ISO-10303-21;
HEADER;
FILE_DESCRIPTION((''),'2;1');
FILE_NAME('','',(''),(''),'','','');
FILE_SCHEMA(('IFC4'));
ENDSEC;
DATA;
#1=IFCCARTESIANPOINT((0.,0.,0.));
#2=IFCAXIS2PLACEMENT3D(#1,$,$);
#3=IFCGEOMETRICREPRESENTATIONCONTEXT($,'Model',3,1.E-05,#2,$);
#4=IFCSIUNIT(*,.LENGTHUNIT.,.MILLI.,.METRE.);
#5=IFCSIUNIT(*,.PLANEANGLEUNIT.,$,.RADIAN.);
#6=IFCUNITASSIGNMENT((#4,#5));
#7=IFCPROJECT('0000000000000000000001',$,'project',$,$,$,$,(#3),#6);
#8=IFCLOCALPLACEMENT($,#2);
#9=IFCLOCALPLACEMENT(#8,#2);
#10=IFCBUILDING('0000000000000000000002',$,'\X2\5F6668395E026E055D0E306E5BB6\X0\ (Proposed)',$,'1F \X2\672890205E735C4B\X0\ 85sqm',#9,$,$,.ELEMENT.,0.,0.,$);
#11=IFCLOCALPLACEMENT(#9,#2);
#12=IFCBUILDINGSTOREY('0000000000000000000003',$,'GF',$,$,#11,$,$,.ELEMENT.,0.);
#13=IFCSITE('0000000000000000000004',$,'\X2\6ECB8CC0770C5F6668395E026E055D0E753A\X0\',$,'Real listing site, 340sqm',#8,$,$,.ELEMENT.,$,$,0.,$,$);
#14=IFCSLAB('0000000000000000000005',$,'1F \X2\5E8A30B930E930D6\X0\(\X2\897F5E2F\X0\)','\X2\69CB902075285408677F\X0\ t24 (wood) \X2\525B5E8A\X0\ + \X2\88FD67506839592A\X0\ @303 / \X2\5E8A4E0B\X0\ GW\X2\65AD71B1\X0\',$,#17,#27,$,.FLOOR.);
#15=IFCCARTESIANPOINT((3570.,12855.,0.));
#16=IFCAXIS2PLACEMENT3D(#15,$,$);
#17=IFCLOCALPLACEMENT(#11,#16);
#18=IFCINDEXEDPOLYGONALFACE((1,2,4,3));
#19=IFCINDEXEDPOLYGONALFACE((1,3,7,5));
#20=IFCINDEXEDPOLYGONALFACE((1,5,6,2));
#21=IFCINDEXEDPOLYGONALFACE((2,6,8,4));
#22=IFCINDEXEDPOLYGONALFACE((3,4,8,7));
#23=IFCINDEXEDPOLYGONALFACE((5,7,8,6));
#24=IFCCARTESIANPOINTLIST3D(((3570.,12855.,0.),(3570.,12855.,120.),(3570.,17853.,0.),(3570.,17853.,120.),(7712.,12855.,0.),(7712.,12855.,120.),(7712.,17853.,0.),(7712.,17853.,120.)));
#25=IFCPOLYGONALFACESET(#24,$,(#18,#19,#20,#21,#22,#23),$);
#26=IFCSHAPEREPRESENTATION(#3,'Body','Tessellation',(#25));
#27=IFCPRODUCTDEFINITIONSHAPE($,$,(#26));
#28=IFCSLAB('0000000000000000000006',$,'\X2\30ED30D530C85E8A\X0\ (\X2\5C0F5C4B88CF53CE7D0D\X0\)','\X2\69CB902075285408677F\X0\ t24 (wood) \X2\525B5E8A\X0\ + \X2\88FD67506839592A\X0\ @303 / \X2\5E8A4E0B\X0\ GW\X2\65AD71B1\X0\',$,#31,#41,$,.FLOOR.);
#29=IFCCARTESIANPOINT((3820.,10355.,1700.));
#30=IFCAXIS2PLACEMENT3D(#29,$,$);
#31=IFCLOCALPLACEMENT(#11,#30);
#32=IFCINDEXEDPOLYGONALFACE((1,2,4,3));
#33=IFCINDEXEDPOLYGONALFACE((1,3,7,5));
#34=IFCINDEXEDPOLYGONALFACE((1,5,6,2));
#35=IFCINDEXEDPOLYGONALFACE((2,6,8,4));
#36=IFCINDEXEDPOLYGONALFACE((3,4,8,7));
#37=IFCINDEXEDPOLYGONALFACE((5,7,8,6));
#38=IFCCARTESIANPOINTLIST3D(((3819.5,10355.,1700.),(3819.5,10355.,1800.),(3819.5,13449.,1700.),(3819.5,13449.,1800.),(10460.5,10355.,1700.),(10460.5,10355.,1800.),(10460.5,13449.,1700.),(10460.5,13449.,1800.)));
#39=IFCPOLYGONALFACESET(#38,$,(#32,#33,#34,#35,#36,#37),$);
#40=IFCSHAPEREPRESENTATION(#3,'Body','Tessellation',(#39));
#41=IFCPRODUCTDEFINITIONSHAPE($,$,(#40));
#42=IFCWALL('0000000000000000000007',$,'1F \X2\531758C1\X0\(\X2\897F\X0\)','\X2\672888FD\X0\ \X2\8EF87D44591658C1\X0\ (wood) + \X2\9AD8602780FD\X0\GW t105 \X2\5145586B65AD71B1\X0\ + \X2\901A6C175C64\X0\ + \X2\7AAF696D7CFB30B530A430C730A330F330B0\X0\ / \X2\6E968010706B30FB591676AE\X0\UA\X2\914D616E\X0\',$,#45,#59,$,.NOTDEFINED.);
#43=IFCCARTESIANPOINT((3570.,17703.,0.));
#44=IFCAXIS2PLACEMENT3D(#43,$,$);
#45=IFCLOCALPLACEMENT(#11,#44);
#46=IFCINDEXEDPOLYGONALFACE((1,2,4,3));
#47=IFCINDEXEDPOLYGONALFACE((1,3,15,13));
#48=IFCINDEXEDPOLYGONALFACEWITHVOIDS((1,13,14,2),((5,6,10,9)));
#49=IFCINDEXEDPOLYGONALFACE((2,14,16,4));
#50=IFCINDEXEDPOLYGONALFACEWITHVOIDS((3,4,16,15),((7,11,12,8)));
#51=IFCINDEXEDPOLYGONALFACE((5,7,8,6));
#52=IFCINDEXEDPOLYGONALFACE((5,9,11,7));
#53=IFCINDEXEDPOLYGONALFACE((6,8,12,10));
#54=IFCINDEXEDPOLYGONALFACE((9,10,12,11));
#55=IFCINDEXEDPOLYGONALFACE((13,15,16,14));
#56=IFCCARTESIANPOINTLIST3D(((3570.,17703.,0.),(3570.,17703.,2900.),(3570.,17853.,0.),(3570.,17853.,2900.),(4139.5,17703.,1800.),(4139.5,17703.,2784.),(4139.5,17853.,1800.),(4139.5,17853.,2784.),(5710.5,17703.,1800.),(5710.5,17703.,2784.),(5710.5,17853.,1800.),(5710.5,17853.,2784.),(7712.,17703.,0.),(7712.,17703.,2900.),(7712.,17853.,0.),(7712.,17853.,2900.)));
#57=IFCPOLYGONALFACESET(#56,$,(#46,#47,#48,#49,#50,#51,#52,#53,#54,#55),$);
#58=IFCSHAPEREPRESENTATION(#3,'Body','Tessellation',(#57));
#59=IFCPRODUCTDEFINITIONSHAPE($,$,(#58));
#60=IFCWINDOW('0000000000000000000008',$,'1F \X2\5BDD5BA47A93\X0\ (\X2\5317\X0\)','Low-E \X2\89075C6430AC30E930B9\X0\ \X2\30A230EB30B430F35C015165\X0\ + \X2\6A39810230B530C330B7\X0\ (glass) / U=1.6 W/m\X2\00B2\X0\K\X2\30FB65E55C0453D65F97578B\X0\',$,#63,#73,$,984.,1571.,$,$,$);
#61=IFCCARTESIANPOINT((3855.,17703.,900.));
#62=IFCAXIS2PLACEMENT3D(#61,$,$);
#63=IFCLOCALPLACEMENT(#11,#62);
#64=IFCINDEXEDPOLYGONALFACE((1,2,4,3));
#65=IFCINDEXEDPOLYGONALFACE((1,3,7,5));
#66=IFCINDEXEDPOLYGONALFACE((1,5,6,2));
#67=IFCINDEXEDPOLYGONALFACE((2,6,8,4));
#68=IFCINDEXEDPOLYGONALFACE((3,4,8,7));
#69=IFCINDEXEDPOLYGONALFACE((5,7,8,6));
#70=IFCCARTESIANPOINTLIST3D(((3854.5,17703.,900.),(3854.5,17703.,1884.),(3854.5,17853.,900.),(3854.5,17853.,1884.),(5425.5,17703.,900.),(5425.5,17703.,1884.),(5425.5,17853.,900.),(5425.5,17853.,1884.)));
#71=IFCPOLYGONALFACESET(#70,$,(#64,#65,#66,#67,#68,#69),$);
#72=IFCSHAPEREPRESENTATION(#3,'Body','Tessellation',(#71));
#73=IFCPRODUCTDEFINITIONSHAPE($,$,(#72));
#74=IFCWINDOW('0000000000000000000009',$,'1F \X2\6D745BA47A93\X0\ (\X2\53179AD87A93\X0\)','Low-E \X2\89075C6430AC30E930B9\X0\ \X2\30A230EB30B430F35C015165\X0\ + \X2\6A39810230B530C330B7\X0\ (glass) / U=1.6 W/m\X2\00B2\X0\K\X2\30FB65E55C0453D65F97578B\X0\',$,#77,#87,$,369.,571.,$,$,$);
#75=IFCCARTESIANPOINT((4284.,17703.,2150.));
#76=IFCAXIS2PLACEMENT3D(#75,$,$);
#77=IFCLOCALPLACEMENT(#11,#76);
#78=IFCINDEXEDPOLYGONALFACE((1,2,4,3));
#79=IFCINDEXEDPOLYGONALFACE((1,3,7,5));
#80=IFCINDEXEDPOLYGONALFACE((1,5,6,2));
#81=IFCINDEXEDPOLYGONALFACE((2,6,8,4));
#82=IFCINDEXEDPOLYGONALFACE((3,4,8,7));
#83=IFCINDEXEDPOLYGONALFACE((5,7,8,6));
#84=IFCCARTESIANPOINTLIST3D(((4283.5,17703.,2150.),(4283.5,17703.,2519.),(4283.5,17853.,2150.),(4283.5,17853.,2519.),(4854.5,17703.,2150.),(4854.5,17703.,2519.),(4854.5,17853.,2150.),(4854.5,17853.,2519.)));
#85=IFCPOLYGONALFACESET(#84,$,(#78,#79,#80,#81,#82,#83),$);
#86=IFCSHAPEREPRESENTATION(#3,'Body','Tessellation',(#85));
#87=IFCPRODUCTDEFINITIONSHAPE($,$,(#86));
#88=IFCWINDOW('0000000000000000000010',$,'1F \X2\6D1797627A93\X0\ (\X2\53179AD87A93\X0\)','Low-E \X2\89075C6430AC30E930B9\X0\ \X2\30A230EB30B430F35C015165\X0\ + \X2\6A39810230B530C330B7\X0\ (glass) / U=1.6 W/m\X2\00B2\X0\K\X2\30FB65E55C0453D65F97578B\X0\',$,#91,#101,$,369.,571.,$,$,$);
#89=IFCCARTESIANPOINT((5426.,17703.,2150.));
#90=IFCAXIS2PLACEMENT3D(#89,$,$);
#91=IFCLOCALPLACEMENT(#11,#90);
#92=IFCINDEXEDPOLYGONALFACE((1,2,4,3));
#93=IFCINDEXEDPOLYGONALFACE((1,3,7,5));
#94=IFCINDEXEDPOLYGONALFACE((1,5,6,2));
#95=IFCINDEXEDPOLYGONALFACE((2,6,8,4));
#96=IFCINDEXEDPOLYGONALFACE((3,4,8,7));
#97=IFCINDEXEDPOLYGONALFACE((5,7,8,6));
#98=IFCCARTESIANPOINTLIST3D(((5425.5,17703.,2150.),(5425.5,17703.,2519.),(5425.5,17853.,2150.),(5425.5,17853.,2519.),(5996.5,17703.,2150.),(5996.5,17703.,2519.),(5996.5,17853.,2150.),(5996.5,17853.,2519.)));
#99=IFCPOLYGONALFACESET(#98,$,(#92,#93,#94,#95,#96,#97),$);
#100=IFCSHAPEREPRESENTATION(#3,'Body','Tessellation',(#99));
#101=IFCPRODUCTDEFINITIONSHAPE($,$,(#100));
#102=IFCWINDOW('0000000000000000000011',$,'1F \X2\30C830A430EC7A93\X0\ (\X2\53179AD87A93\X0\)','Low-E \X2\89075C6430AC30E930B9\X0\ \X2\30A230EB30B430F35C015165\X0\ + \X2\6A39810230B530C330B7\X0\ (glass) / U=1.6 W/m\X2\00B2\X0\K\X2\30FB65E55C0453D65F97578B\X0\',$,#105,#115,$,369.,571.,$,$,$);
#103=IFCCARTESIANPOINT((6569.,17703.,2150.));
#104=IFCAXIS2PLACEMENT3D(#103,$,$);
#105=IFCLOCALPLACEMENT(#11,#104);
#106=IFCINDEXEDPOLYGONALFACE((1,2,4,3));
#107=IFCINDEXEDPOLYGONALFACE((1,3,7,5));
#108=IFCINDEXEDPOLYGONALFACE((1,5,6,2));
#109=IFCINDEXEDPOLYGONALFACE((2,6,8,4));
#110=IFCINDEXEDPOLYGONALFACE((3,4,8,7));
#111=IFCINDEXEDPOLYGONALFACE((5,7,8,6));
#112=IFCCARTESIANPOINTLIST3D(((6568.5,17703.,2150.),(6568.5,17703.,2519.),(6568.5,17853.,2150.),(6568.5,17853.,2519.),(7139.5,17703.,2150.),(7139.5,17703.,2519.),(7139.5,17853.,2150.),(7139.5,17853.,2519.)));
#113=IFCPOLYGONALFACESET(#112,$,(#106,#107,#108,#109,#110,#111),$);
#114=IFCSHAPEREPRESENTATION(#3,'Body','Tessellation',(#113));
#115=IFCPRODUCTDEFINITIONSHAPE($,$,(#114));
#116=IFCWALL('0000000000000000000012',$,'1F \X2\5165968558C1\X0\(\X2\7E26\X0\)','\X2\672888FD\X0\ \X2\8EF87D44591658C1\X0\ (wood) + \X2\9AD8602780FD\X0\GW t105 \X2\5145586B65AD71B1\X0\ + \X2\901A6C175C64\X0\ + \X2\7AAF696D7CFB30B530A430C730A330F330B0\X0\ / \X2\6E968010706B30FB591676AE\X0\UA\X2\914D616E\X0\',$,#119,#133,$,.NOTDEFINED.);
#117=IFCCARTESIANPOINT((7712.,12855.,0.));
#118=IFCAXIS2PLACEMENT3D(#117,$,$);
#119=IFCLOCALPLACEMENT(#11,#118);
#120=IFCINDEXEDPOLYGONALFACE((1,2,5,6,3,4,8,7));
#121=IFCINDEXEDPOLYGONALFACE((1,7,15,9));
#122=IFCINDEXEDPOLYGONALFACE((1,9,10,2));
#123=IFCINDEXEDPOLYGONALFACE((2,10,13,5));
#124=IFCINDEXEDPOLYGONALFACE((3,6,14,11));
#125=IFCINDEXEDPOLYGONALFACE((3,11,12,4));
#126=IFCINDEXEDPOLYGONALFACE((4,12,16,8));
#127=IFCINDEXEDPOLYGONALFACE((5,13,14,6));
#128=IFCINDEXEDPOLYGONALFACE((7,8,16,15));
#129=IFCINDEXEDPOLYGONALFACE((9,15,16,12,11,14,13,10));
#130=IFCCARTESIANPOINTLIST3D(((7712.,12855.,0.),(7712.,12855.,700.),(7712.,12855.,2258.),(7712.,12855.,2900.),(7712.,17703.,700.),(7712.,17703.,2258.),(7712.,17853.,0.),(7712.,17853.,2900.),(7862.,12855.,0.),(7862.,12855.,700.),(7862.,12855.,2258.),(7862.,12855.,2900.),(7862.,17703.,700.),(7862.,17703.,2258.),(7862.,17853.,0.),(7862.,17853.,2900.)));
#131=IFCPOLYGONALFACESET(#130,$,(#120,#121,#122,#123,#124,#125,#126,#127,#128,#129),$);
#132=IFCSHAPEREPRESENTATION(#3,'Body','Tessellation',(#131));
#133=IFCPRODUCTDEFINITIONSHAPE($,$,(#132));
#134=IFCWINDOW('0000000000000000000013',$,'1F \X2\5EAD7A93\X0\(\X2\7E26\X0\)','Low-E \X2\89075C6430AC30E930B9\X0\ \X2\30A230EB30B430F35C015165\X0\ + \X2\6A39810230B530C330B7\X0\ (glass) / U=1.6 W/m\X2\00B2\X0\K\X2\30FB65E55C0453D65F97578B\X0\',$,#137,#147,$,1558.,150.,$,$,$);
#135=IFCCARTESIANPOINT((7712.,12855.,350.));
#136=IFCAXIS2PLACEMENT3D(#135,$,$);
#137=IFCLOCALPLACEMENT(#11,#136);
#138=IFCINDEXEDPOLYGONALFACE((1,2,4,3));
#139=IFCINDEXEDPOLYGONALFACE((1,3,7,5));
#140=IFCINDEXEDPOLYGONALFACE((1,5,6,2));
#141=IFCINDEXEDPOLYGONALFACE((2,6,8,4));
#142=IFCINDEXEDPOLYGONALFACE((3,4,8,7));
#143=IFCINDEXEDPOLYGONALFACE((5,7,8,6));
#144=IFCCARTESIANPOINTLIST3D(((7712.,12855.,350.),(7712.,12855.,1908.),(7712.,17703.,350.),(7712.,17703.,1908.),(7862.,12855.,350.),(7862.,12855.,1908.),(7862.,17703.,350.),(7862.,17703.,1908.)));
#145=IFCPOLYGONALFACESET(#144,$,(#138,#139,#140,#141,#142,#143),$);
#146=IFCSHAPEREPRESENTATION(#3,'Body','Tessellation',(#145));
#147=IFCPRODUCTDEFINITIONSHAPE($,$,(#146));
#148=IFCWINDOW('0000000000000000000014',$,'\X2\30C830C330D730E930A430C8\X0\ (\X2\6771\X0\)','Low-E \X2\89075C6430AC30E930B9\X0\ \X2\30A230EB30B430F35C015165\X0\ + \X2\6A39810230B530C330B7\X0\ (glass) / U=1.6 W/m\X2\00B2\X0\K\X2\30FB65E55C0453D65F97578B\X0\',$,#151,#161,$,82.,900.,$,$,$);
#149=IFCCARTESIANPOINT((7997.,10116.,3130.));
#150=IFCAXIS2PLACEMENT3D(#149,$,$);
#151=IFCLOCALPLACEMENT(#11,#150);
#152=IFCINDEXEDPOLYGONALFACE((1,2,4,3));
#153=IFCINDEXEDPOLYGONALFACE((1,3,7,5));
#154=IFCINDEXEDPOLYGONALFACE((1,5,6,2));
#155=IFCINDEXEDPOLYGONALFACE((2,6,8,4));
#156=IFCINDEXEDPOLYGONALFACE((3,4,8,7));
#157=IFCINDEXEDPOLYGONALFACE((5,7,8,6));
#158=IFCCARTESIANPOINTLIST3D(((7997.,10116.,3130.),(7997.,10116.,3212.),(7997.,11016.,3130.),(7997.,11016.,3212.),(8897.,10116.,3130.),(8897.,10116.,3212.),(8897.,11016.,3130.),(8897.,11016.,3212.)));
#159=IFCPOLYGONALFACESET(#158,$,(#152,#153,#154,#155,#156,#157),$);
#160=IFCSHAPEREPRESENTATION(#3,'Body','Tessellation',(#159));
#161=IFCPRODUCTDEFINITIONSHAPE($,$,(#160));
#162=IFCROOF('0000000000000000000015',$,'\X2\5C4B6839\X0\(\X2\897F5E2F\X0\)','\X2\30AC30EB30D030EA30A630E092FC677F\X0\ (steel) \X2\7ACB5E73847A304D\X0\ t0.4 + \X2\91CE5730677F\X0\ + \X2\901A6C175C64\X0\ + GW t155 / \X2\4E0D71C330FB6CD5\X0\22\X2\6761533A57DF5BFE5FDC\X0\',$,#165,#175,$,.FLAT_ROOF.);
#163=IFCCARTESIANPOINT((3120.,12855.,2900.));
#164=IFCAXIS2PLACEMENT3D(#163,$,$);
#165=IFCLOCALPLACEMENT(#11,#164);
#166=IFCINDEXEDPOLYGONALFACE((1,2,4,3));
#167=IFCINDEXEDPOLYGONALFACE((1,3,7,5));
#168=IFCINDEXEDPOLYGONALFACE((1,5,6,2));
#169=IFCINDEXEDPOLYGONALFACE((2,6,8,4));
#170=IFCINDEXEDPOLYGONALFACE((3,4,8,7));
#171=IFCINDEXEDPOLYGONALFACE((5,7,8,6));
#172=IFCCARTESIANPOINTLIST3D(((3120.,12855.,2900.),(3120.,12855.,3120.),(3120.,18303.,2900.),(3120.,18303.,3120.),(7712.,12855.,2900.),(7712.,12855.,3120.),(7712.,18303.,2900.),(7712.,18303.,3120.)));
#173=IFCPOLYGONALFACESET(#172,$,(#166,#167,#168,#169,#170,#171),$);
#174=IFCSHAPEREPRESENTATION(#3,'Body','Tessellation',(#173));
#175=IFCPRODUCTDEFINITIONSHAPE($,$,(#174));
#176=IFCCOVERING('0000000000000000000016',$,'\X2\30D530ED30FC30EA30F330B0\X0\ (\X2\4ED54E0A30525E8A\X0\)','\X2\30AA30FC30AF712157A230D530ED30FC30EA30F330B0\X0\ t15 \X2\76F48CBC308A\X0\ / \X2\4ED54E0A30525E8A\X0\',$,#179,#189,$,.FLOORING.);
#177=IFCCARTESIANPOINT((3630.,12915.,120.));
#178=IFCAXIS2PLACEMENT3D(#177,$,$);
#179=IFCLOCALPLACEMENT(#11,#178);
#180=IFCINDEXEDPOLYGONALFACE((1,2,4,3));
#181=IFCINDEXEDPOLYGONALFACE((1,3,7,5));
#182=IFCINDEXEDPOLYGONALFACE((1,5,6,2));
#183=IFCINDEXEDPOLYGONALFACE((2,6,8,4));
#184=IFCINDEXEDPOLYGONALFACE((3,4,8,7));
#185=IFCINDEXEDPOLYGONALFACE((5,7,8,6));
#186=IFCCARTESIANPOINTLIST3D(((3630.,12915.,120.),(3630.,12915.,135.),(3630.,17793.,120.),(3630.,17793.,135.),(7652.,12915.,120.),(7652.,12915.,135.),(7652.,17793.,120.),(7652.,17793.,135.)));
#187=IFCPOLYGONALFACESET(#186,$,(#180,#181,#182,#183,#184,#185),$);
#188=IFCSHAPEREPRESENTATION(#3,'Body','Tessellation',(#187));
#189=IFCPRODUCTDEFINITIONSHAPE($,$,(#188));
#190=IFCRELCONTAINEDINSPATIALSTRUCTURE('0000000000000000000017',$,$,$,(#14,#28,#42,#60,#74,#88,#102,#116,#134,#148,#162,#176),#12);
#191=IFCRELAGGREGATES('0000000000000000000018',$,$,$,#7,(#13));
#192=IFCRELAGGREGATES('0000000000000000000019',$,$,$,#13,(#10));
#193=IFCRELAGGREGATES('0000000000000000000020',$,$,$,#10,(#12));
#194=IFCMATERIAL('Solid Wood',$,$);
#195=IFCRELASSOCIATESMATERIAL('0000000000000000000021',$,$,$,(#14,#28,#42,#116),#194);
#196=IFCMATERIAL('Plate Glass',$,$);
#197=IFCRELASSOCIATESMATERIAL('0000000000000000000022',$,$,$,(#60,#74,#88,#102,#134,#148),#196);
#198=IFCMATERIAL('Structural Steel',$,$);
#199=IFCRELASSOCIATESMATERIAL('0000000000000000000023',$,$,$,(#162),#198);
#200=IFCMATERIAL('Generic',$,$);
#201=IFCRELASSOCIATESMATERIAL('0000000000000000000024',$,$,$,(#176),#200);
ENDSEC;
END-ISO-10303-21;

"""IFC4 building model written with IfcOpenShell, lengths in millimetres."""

from ifc_helpers import new_model, si_unit, frame, frame_2d, origin, place, context, project, spatial, rectangle, extrude, material, element, fill, save


model = new_model("IFC4")

# Units and contexts
model_context = context("Model", 3, precision=1e-05, world=origin())
ifc_project = project(units=[si_unit("LENGTHUNIT", "METRE", prefix="MILLI"), si_unit("PLANEANGLEUNIT", "RADIAN")], contexts=[model_context])

# Site, building, storey
site_placement = place(None, origin())
site = spatial("IfcSite", under=ifc_project, at=site_placement, Name="滋賀県彦根市清崎町", ObjectType="Real listing site, 340sqm", CompositionType="ELEMENT", RefElevation=0.0)
building_placement = place(site_placement, origin())
building = spatial("IfcBuilding", under=site, at=building_placement, Name="彦根市清崎の家 (Proposed)", ObjectType="1F 木造平屋 85sqm", CompositionType="ELEMENT", ElevationOfRefHeight=0.0, ElevationOfTerrain=0.0)
storey_placement = place(building_placement, origin())
storey = spatial("IfcBuildingStorey", under=building, at=storey_placement, Name="GF", CompositionType="ELEMENT", Elevation=0.0)

# Slabs
ifc_material_1 = material(Name="Solid Wood")
slab_1_placement = place(storey_placement, frame((3570.0, 12855.0, 0.0)))
element("IfcSlab", 1, at=slab_1_placement, inside=storey, material=ifc_material_1, Name="1F 床スラブ(西帯)", Description="構造用合板 t24 (wood) 剛床 + 製材根太 @303 / 床下 GW断熱", PredefinedType="FLOOR", context=model_context, shape_type="SweptSolid", body=[
    extrude(rectangle(XDim=4142.0, YDim=4998.0, at=frame_2d((2071.0, 2499.0))), frame((3570.0, 12855.0, 0.0)), (0.0, 0.0, 1.0), 120.0),
])
slab_2_placement = place(storey_placement, frame((3820.0, 10355.0, 1700.0)))
element("IfcSlab", 2, at=slab_2_placement, inside=storey, material=ifc_material_1, Name="ロフト床 (小屋裏収納)", Description="構造用合板 t24 (wood) 剛床 + 製材根太 @303 / 床下 GW断熱", PredefinedType="FLOOR", context=model_context, shape_type="SweptSolid", body=[
    extrude(rectangle(XDim=6641.0, YDim=3094.0, at=frame_2d((3320.0, 1547.0))), frame((3820.0, 10355.0, 1700.0)), (0.0, 0.0, 1.0), 100.0),
])

# Wall, openings, windows
wall_1_placement = place(storey_placement, frame((3570.0, 17703.0, 0.0)))
wall_1 = element("IfcWall", 3, at=wall_1_placement, inside=storey, material=ifc_material_1, Name="1F 北壁(西)", Description="木製 軸組外壁 (wood) + 高性能GW t105 充填断熱 + 通気層 + 窯業系サイディング / 準耐火・外皮UA配慮", PredefinedType="NOTDEFINED", context=model_context, shape_type="SweptSolid", body=[
    extrude(rectangle(XDim=4142.0, YDim=150.0, at=frame_2d((2071.0, 75.0))), frame((3570.0, 17703.0, 0.0)), (0.0, 0.0, 1.0), 2900.0),
])
opening_1_placement = place(storey_placement, frame((3855.0, 17703.0, 900.0)))
opening_1 = element("IfcOpeningElement", 4, at=opening_1_placement, cuts=wall_1, PredefinedType="NOTDEFINED", context=model_context, shape_type="SweptSolid", body=[
    extrude(rectangle(XDim=1571.0, YDim=150.0, at=frame_2d((785.0, 75.0))), frame((3855.0, 17703.0, 900.0)), (0.0, 0.0, 1.0), 984.0),
])
opening_2_placement = place(storey_placement, frame((4284.0, 17703.0, 2150.0)))
opening_2 = element("IfcOpeningElement", 5, at=opening_2_placement, cuts=wall_1, PredefinedType="NOTDEFINED", context=model_context, shape_type="SweptSolid", body=[
    extrude(rectangle(XDim=571.0, YDim=150.0, at=frame_2d((285.0, 75.0))), frame((4284.0, 17703.0, 2150.0)), (0.0, 0.0, 1.0), 369.0),
])
opening_3_placement = place(storey_placement, frame((5426.0, 17703.0, 2150.0)))
opening_3 = element("IfcOpeningElement", 6, at=opening_3_placement, cuts=wall_1, PredefinedType="NOTDEFINED", context=model_context, shape_type="SweptSolid", body=[
    extrude(rectangle(XDim=571.0, YDim=150.0, at=frame_2d((285.0, 75.0))), frame((5426.0, 17703.0, 2150.0)), (0.0, 0.0, 1.0), 369.0),
])
opening_4_placement = place(storey_placement, frame((6569.0, 17703.0, 2150.0)))
opening_4 = element("IfcOpeningElement", 7, at=opening_4_placement, cuts=wall_1, PredefinedType="NOTDEFINED", context=model_context, shape_type="SweptSolid", body=[
    extrude(rectangle(XDim=571.0, YDim=150.0, at=frame_2d((285.0, 75.0))), frame((6569.0, 17703.0, 2150.0)), (0.0, 0.0, 1.0), 369.0),
])
ifc_material_2 = material(Name="Plate Glass")
window_1_placement = place(storey_placement, frame((3855.0, 17703.0, 900.0)))
window_1 = element("IfcWindow", 8, at=window_1_placement, inside=storey, material=ifc_material_2, Name="1F 寝室窓 (北)", Description="Low-E 複層ガラス アルゴン封入 + 樹脂サッシ (glass) / U=1.6 W/m²K・日射取得型", OverallHeight=984.0, OverallWidth=1571.0, context=model_context, shape_type="SweptSolid", body=[
    extrude(rectangle(XDim=1571.0, YDim=150.0, at=frame_2d((785.0, 75.0))), frame((3855.0, 17703.0, 900.0)), (0.0, 0.0, 1.0), 984.0),
])
fill(opening_1, window_1)
window_2_placement = place(storey_placement, frame((4284.0, 17703.0, 2150.0)))
window_2 = element("IfcWindow", 9, at=window_2_placement, inside=storey, material=ifc_material_2, Name="1F 浴室窓 (北高窓)", Description="Low-E 複層ガラス アルゴン封入 + 樹脂サッシ (glass) / U=1.6 W/m²K・日射取得型", OverallHeight=369.0, OverallWidth=571.0, context=model_context, shape_type="SweptSolid", body=[
    extrude(rectangle(XDim=571.0, YDim=150.0, at=frame_2d((285.0, 75.0))), frame((4284.0, 17703.0, 2150.0)), (0.0, 0.0, 1.0), 369.0),
])
fill(opening_2, window_2)
window_3_placement = place(storey_placement, frame((5426.0, 17703.0, 2150.0)))
window_3 = element("IfcWindow", 10, at=window_3_placement, inside=storey, material=ifc_material_2, Name="1F 洗面窓 (北高窓)", Description="Low-E 複層ガラス アルゴン封入 + 樹脂サッシ (glass) / U=1.6 W/m²K・日射取得型", OverallHeight=369.0, OverallWidth=571.0, context=model_context, shape_type="SweptSolid", body=[
    extrude(rectangle(XDim=571.0, YDim=150.0, at=frame_2d((285.0, 75.0))), frame((5426.0, 17703.0, 2150.0)), (0.0, 0.0, 1.0), 369.0),
])
fill(opening_3, window_3)
window_4_placement = place(storey_placement, frame((6569.0, 17703.0, 2150.0)))
window_4 = element("IfcWindow", 11, at=window_4_placement, inside=storey, material=ifc_material_2, Name="1F トイレ窓 (北高窓)", Description="Low-E 複層ガラス アルゴン封入 + 樹脂サッシ (glass) / U=1.6 W/m²K・日射取得型", OverallHeight=369.0, OverallWidth=571.0, context=model_context, shape_type="SweptSolid", body=[
    extrude(rectangle(XDim=571.0, YDim=150.0, at=frame_2d((285.0, 75.0))), frame((6569.0, 17703.0, 2150.0)), (0.0, 0.0, 1.0), 369.0),
])
fill(opening_4, window_4)

# Wall, opening, window
wall_2_placement = place(storey_placement, frame((7712.0, 12855.0, 0.0)))
wall_2 = element("IfcWall", 12, at=wall_2_placement, inside=storey, material=ifc_material_1, Name="1F 入隅壁(縦)", Description="木製 軸組外壁 (wood) + 高性能GW t105 充填断熱 + 通気層 + 窯業系サイディング / 準耐火・外皮UA配慮", PredefinedType="NOTDEFINED", context=model_context, shape_type="SweptSolid", body=[
    extrude(rectangle(XDim=150.0, YDim=4998.0, at=frame_2d((75.0, 2499.0))), frame((7712.0, 12855.0, 0.0)), (0.0, 0.0, 1.0), 2900.0),
])
opening_5_placement = place(storey_placement, frame((7712.0, 12855.0, 350.0)))
opening_5 = element("IfcOpeningElement", 13, at=opening_5_placement, cuts=wall_2, PredefinedType="NOTDEFINED", context=model_context, shape_type="SweptSolid", body=[
    extrude(rectangle(XDim=150.0, YDim=4848.0, at=frame_2d((75.0, 2424.0))), frame((7712.0, 12855.0, 350.0)), (0.0, 0.0, 1.0), 1558.0),
])
window_5_placement = place(storey_placement, frame((7712.0, 12855.0, 350.0)))
window_5 = element("IfcWindow", 14, at=window_5_placement, inside=storey, material=ifc_material_2, Name="1F 庭窓(縦)", Description="Low-E 複層ガラス アルゴン封入 + 樹脂サッシ (glass) / U=1.6 W/m²K・日射取得型", OverallHeight=1558.0, OverallWidth=150.0, context=model_context, shape_type="SweptSolid", body=[
    extrude(rectangle(XDim=150.0, YDim=4848.0, at=frame_2d((75.0, 2424.0))), frame((7712.0, 12855.0, 350.0)), (0.0, 0.0, 1.0), 1558.0),
])
fill(opening_5, window_5)

# Window
window_6_placement = place(storey_placement, frame((7997.0, 10116.0, 3130.0)))
element("IfcWindow", 15, at=window_6_placement, inside=storey, material=ifc_material_2, Name="トップライト (東)", Description="Low-E 複層ガラス アルゴン封入 + 樹脂サッシ (glass) / U=1.6 W/m²K・日射取得型", OverallHeight=82.0, OverallWidth=900.0, context=model_context, shape_type="SweptSolid", body=[
    extrude(rectangle(XDim=900.0, YDim=900.0, at=frame_2d((450.0, 450.0))), frame((7997.0, 10116.0, 3130.0)), (0.0, 0.0, 1.0), 82.0),
])

# Roof
ifc_material_3 = material(Name="Structural Steel")
roof_placement = place(storey_placement, frame((3120.0, 12855.0, 2900.0)))
element("IfcRoof", 16, at=roof_placement, inside=storey, material=ifc_material_3, Name="屋根(西帯)", Description="ガルバリウム鋼板 (steel) 立平葺き t0.4 + 野地板 + 通気層 + GW t155 / 不燃・法22条区域対応", PredefinedType="FLAT_ROOF", context=model_context, shape_type="SweptSolid", body=[
    extrude(rectangle(XDim=4592.0, YDim=5448.0, at=frame_2d((2296.0, 2724.0))), frame((3120.0, 12855.0, 2900.0)), (0.0, 0.0, 1.0), 220.0),
])

# Covering
ifc_material_4 = material(Name="Generic")
covering_placement = place(storey_placement, frame((3630.0, 12915.0, 120.0)))
element("IfcCovering", 17, at=covering_placement, inside=storey, material=ifc_material_4, Name="フローリング (仕上げ床)", Description="オーク無垢フローリング t15 直貼り / 仕上げ床", PredefinedType="FLOORING", context=model_context, shape_type="SweptSolid", body=[
    extrude(rectangle(XDim=4022.0, YDim=4878.0, at=frame_2d((2011.0, 2439.0))), frame((3630.0, 12915.0, 120.0)), (0.0, 0.0, 1.0), 15.0),
])

save(model, "model.ifc")
